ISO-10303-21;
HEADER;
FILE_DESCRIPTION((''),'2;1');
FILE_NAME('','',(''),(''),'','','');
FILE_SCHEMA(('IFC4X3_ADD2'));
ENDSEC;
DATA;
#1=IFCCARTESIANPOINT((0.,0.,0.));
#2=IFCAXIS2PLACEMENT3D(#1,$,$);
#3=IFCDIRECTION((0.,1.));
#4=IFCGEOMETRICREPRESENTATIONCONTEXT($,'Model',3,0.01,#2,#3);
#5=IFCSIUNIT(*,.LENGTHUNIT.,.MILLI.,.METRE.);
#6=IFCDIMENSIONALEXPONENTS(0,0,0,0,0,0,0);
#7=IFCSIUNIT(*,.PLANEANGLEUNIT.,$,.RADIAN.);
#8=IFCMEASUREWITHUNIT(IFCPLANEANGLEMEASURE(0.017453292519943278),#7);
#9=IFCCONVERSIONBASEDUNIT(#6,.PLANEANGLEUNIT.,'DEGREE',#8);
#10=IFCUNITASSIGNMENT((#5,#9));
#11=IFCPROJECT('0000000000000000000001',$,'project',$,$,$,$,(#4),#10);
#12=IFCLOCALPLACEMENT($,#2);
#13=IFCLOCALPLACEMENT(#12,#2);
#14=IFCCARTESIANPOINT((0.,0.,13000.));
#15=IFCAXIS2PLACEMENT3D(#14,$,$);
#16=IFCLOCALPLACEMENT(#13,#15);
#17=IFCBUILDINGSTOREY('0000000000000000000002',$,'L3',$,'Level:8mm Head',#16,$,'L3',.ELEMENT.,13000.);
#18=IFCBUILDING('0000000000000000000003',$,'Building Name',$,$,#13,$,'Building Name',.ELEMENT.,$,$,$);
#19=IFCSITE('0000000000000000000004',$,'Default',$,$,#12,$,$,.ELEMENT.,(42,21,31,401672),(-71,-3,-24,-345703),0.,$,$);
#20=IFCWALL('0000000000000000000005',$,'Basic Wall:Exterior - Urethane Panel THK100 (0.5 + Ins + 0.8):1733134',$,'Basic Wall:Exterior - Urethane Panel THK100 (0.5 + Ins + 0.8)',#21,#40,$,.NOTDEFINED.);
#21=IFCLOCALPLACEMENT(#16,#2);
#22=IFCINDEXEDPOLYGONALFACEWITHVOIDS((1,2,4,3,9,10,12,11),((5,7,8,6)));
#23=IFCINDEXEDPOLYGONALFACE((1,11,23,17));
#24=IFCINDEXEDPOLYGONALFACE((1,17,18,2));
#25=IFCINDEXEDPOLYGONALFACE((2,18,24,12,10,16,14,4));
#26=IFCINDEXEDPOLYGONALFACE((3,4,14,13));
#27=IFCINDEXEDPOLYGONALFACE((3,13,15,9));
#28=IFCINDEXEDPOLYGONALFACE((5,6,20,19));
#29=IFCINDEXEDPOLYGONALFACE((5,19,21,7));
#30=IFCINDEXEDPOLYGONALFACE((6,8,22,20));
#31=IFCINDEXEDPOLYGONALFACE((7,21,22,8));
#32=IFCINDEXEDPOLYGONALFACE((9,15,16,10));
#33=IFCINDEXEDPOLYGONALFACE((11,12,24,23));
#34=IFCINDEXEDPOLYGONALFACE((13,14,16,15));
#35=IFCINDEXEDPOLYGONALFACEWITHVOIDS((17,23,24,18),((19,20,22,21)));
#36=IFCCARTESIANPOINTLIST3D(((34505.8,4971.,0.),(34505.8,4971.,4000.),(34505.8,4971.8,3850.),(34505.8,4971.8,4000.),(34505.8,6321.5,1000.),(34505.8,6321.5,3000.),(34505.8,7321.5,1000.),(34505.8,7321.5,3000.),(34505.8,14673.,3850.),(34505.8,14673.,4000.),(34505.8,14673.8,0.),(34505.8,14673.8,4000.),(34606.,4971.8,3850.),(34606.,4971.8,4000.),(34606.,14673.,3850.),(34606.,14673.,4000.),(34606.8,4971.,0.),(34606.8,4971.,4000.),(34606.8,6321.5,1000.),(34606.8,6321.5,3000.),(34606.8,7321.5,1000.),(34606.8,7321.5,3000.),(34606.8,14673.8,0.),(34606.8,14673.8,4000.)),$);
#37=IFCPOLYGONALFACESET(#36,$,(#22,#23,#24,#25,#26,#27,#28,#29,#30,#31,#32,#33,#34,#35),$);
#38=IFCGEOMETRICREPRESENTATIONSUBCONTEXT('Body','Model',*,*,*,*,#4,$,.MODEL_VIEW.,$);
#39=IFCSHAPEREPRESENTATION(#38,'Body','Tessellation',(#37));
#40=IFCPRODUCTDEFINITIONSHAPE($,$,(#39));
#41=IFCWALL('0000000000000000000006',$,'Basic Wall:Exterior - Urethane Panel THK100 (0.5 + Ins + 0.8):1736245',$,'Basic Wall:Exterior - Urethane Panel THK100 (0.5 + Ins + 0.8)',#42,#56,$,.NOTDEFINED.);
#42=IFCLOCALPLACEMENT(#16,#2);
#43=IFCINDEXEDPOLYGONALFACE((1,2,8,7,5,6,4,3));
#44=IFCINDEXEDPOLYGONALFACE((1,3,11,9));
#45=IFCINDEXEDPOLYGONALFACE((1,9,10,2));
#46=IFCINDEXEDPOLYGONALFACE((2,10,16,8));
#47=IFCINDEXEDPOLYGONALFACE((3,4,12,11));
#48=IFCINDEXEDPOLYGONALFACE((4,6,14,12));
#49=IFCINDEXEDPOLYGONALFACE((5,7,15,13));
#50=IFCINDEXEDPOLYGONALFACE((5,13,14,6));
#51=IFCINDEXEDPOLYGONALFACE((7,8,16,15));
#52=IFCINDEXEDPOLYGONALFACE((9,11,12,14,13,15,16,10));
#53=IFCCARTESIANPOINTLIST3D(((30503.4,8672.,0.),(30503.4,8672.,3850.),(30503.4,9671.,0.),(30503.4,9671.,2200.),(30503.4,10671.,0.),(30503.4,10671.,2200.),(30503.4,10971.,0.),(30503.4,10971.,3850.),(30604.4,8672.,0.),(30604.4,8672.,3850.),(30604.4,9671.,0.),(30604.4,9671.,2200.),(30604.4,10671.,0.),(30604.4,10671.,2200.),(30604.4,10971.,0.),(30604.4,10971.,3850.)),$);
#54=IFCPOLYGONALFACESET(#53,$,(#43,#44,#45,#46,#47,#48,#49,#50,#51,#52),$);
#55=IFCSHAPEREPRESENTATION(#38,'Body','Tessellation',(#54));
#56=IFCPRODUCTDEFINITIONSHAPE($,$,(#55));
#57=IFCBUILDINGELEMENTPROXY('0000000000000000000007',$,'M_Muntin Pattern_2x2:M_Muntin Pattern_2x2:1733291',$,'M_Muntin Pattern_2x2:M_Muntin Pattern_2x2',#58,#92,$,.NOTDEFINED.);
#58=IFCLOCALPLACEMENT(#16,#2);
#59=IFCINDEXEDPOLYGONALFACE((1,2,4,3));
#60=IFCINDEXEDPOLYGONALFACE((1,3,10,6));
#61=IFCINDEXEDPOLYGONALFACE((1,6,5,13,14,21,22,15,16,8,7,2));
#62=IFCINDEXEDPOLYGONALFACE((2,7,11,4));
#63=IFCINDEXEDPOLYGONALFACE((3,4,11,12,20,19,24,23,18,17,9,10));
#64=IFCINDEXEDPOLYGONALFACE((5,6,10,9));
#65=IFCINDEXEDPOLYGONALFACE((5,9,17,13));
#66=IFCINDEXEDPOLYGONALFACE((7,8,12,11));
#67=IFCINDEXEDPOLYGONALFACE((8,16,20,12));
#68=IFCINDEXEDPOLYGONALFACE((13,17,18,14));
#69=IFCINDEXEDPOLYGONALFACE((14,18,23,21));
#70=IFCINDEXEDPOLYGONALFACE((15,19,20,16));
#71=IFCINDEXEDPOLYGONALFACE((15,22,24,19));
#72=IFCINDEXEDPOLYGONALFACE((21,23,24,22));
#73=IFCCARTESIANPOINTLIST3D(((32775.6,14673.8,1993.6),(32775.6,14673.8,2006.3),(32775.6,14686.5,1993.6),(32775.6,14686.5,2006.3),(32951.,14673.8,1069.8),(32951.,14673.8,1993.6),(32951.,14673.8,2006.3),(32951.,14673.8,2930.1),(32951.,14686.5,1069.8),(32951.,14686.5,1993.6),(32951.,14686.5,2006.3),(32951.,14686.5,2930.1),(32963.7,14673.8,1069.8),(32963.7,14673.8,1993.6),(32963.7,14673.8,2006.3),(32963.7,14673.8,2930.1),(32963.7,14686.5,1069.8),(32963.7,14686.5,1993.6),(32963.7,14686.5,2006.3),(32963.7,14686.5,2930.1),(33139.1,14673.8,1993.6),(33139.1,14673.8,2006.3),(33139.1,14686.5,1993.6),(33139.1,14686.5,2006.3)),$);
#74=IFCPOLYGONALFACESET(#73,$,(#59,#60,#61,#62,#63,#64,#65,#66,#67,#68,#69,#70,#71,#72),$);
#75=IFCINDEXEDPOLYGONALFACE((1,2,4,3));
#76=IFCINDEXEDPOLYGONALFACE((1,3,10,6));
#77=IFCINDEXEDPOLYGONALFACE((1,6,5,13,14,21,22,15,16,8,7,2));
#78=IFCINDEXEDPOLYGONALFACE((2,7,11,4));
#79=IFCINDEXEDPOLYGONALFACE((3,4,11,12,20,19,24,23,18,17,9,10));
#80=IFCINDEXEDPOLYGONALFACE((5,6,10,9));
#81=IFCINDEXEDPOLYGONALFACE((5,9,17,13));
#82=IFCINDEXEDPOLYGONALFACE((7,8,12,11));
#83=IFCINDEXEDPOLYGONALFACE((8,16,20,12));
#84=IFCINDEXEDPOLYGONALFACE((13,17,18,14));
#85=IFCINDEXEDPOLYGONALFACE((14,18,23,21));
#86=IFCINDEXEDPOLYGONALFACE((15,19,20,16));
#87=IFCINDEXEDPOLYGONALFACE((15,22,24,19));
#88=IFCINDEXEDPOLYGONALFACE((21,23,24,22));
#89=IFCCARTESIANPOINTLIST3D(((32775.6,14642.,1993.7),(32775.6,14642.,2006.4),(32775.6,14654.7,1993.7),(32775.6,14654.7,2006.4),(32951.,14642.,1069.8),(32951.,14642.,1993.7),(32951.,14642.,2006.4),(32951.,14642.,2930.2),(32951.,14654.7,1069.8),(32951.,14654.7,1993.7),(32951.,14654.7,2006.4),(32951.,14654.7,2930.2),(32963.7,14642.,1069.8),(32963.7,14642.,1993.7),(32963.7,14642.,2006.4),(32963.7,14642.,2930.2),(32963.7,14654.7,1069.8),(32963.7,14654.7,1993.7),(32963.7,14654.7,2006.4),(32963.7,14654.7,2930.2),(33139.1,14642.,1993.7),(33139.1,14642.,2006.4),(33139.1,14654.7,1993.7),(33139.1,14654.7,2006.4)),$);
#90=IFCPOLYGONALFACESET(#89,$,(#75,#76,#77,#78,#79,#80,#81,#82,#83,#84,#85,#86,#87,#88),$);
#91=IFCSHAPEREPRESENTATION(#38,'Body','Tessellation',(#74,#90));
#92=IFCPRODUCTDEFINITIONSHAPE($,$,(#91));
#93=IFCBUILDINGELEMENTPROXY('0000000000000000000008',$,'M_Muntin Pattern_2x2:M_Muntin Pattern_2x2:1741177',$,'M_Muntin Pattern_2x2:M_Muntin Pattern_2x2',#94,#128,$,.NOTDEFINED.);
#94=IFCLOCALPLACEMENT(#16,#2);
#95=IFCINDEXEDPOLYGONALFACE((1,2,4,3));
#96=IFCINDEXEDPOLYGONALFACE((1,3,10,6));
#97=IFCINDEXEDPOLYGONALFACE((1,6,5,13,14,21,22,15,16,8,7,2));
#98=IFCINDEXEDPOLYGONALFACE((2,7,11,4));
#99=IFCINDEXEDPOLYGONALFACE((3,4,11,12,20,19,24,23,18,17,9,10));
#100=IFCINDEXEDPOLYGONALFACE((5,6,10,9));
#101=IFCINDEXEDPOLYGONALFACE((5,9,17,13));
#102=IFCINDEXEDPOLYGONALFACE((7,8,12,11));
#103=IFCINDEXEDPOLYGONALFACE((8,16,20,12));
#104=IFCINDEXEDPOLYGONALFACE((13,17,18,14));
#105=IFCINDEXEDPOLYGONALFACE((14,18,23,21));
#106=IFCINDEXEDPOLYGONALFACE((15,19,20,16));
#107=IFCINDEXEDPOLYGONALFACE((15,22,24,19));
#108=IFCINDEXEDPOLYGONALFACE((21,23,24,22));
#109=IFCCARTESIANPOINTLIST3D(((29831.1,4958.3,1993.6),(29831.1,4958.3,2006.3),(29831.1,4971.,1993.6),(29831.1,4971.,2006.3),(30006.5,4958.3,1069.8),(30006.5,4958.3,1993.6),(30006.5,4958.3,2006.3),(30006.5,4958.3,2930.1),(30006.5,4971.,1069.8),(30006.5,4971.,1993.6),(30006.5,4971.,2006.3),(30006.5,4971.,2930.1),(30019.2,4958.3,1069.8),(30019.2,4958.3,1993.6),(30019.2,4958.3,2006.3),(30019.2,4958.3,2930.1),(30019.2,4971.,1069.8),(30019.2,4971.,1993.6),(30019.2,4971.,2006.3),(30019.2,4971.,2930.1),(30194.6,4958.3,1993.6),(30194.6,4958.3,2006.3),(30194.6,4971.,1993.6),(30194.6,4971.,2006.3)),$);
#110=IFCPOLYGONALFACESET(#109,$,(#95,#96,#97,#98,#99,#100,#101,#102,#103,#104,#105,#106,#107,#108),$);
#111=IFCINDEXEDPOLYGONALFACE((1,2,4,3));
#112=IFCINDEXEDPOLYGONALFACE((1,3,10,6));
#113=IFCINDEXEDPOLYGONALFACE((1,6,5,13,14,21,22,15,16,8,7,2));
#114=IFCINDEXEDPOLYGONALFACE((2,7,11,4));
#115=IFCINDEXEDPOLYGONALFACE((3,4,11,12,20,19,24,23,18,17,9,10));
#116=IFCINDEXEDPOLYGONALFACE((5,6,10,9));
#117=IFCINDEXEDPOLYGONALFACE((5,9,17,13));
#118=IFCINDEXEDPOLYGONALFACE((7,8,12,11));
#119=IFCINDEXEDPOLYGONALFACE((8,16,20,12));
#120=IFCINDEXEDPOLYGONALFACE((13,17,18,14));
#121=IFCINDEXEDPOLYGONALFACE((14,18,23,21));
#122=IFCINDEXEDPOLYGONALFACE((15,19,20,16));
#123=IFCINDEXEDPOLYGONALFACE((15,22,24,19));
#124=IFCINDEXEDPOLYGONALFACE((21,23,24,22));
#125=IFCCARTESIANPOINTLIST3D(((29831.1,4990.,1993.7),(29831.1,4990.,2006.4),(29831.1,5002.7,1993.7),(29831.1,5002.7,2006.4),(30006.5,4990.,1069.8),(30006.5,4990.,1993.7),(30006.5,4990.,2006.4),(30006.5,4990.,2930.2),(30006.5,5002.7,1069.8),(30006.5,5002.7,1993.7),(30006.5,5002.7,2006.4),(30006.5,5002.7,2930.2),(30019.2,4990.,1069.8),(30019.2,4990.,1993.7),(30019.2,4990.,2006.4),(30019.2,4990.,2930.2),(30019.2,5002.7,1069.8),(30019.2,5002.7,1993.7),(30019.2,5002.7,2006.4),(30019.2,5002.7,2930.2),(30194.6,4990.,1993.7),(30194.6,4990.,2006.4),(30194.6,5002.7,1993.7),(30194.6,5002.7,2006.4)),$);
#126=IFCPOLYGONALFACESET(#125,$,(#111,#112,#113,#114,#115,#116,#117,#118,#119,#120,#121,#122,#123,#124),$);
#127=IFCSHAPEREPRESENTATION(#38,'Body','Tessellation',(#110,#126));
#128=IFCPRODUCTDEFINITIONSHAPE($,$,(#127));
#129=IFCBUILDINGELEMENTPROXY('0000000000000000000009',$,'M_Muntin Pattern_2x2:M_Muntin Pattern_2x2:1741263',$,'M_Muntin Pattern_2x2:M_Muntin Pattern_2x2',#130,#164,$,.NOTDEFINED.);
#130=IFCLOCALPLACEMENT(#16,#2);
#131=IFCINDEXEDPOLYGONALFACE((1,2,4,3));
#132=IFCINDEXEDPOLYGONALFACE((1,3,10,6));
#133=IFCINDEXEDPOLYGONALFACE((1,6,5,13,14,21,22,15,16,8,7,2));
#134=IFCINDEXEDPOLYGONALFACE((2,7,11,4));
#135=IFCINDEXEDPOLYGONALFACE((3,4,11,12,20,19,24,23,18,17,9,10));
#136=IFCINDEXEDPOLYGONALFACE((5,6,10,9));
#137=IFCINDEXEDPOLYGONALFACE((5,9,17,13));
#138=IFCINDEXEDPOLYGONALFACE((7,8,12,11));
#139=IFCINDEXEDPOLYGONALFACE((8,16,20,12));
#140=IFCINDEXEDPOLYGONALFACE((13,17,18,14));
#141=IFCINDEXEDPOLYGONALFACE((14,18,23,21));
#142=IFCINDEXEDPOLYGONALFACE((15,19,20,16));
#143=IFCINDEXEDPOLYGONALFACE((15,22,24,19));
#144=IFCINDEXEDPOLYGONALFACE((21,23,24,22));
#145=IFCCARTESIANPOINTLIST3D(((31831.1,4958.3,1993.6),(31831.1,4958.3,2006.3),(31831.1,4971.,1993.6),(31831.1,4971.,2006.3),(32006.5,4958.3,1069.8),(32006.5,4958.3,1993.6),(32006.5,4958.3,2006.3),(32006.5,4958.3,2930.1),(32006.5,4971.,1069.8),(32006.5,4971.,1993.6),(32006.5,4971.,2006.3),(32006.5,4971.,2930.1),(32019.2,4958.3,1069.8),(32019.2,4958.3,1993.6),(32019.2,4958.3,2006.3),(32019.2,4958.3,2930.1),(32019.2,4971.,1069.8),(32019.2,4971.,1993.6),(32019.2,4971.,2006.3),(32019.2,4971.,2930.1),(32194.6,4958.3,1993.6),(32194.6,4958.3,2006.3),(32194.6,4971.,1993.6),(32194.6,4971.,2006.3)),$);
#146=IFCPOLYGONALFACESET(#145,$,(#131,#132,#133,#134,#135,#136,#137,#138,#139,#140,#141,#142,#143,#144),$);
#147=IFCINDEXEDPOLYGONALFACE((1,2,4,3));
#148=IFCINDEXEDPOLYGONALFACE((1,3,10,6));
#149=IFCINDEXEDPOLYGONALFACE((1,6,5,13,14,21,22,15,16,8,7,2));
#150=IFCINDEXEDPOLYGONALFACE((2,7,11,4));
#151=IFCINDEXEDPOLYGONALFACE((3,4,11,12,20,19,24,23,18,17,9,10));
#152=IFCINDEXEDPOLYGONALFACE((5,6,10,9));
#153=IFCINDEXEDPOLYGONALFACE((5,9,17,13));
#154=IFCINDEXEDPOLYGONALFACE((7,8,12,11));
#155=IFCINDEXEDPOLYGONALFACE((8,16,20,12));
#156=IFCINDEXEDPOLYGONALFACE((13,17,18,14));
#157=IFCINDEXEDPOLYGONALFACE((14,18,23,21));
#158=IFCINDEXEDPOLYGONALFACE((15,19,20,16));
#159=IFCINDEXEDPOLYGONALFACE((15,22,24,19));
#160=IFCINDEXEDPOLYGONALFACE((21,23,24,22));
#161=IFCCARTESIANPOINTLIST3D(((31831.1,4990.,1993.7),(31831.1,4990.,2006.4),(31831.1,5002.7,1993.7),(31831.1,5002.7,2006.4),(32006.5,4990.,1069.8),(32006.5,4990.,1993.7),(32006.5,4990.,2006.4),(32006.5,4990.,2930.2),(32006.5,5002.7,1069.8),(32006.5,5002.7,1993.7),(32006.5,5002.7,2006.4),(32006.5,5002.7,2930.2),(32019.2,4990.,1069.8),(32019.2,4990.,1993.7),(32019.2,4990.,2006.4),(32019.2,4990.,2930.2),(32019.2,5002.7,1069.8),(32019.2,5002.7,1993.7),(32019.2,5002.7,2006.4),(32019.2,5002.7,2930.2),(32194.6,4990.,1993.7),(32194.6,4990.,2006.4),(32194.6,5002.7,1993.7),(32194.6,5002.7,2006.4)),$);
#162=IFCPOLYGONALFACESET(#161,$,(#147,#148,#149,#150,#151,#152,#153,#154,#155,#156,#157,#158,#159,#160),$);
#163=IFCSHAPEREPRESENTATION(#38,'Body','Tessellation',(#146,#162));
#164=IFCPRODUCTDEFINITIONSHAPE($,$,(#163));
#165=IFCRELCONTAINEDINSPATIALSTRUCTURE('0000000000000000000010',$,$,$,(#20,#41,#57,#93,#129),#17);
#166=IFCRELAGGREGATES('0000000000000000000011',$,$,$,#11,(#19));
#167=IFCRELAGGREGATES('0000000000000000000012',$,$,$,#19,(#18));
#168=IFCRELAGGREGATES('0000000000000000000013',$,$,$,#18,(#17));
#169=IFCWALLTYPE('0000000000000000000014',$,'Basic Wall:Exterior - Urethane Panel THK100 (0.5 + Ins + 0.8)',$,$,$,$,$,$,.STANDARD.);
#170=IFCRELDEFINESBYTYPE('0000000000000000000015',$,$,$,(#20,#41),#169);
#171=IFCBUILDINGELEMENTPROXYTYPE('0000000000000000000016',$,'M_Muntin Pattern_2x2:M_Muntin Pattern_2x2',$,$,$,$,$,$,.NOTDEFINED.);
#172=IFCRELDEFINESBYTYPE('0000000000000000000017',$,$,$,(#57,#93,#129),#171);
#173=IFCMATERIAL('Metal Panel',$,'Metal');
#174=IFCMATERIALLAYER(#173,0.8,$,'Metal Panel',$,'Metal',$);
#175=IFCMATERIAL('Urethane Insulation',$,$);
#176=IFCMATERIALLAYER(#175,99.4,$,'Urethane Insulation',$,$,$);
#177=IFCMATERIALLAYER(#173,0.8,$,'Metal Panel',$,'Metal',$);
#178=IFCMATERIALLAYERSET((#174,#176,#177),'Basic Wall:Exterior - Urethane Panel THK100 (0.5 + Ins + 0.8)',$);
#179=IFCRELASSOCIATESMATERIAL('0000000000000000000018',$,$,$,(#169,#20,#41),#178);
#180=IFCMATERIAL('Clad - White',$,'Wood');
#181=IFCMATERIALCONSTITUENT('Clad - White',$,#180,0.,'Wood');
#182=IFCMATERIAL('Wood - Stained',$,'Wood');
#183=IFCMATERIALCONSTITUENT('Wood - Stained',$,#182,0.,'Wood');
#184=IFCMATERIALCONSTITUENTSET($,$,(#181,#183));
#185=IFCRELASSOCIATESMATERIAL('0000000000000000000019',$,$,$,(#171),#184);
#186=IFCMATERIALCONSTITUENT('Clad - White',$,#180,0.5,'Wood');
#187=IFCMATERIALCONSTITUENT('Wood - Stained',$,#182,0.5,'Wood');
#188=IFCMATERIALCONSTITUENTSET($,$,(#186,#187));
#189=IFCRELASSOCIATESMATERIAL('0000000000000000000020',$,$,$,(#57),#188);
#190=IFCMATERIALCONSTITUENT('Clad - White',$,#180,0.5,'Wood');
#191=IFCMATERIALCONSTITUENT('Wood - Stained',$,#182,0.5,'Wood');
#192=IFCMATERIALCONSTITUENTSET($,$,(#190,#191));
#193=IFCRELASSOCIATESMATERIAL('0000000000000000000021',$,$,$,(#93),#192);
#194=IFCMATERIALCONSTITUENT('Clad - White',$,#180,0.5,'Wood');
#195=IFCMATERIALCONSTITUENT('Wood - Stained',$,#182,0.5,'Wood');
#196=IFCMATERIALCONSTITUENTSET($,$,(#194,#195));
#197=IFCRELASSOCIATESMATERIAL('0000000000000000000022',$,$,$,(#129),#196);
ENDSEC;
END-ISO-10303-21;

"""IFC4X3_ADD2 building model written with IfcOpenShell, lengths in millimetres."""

from ifc_helpers import new_model, entity, si_unit, converted_unit, direction, frame, frame_2d, origin, place, context, subcontext, project, spatial, polyline, rectangle, outline, extrude, clip, bounded_halfspace, source, transform, mapped, material, layer, layer_set, constituent, constituent_set, type_object, type_shapes, element, save


model = new_model("IFC4X3_ADD2")

# Units and contexts
model_context = context("Model", 3, precision=0.01, world=origin(), true_north=direction((0.0, 1.0)))
body_context = subcontext(model_context, "Body", "Model", "MODEL_VIEW")
ifc_project = project(units=[si_unit("LENGTHUNIT", "METRE", prefix="MILLI"), converted_unit("PLANEANGLEUNIT", "DEGREE", entity("IfcPlaneAngleMeasure", 0.017453292519943278), si_unit("PLANEANGLEUNIT", "RADIAN"), dimensions=[0, 0, 0, 0, 0, 0, 0])], contexts=[model_context])

# Site, building, storey
site_placement = place(None, origin())
site = spatial("IfcSite", under=ifc_project, at=site_placement, Name="Default", CompositionType="ELEMENT", RefLatitude=(42, 21, 31, 401672), RefLongitude=(-71, -3, -24, -345703), RefElevation=0.0)
building_placement = place(site_placement, origin())
building = spatial("IfcBuilding", under=site, at=building_placement, Name="Building Name", LongName="Building Name", CompositionType="ELEMENT")
storey_placement = place(building_placement, frame((0.0, 0.0, 13000.0)))
storey = spatial("IfcBuildingStorey", under=building, at=storey_placement, Name="L3", ObjectType="Level:8mm Head", LongName="L3", CompositionType="ELEMENT", Elevation=13000.0)

# Walls, openings
ifc_material_1 = material(Name="Metal Panel", Category="Metal")
ifc_layer_1 = layer(ifc_material_1, 0.8, Name="Metal Panel", Category="Metal")
ifc_material_2 = material(Name="Urethane Insulation")
ifc_layer_2 = layer(ifc_material_2, 99.4, Name="Urethane Insulation")
ifc_layer_3 = layer(ifc_material_1, 0.8, Name="Metal Panel", Category="Metal")
ifc_layer_set = layer_set([ifc_layer_1, ifc_layer_2, ifc_layer_3], Name="Basic Wall:Exterior - Urethane Panel THK100 (0.5 + Ins + 0.8)")
wall_type = type_object("IfcWallType", Name="Basic Wall:Exterior - Urethane Panel THK100 (0.5 + Ins + 0.8)", PredefinedType="STANDARD", material=ifc_layer_set)
wall_1_placement = place(storey_placement, frame((34556.3, 14673.8, 0.0), z_axis=(0.0, 0.0, 1.0), x_axis=(0.0, -1.0, 0.0)))
wall_1 = element("IfcWall", 1, at=wall_1_placement, inside=storey, type_object=wall_type, material=ifc_layer_set, Name="Basic Wall:Exterior - Urethane Panel THK100 (0.5 + Ins + 0.8):1733134", ObjectType="Basic Wall:Exterior - Urethane Panel THK100 (0.5 + Ins + 0.8)", PredefinedType="NOTDEFINED", context=body_context, shape_type="Clipping", body=[
    clip(extrude(rectangle(XDim=9702.8, YDim=101.0, at=frame_2d((4851.4, 0.0), x_axis=(-1.0, 0.0))), origin(), (0.0, 0.0, 1.0), 4000.0), bounded_halfspace(frame((0.8, -50.5, 3850.0), z_axis=(0.0, 0.0, -1.0), x_axis=(-1.0, 0.0, 0.0)), True, frame((0.8, -50.5, 3850.0)), polyline([(0.0, 0.0), (100.2, 0.0), (3601.0, 0.0), (3702.0, 0.0), (6001.0, 0.0), (6102.0, 0.0), (9601.0, 0.0), (9701.2, 0.0), (9701.2, 100.2), (0.0, 100.2), (0.0, 0.0)]))),
])
opening_1_placement = place(wall_1_placement, frame((7352.3, -50.5, 1000.0)))
element("IfcOpeningElement", 2, at=opening_1_placement, cuts=wall_1, PredefinedType="OPENING", context=body_context, shape_type="SweptSolid", body=[
    extrude(rectangle(XDim=2000.0, YDim=1000.0, at=frame_2d((1000.0, 500.0), x_axis=(-1.0, 0.0))), frame((0.0, 0.0, 0.0), z_axis=(0.0, 1.0, 0.0), x_axis=(0.0, 0.0, 1.0)), (0.0, 0.0, 1.0), 101.0),
])
wall_2_placement = place(storey_placement, frame((30553.9, 10971.0, 0.0), z_axis=(0.0, 0.0, 1.0), x_axis=(0.0, -1.0, 0.0)))
wall_2 = element("IfcWall", 3, at=wall_2_placement, inside=storey, type_object=wall_type, material=ifc_layer_set, Name="Basic Wall:Exterior - Urethane Panel THK100 (0.5 + Ins + 0.8):1736245", ObjectType="Basic Wall:Exterior - Urethane Panel THK100 (0.5 + Ins + 0.8)", PredefinedType="NOTDEFINED", context=body_context, shape_type="Clipping", body=[
    clip(extrude(rectangle(XDim=2299.0, YDim=101.0, at=frame_2d((1149.5, 0.0), x_axis=(-1.0, 0.0))), origin(), (0.0, 0.0, 1.0), 3850.0), bounded_halfspace(frame((0.0, -50.5, 3850.0), z_axis=(0.0, 0.0, -1.0), x_axis=(-1.0, 0.0, 0.0)), True, frame((0.0, -50.5, 3850.0)), polyline([(0.0, 0.0), (2299.0, 0.0), (2299.0, 101.0), (0.0, 101.0), (0.0, 0.0)]))),
])
opening_2_placement = place(wall_2_placement, frame((300.0, -50.5, 0.0)))
element("IfcOpeningElement", 4, at=opening_2_placement, cuts=wall_2, PredefinedType="OPENING", context=body_context, shape_type="SweptSolid", body=[
    extrude(rectangle(XDim=2200.0, YDim=1000.0, at=frame_2d((1100.0, 500.0), x_axis=(1.0, 0.0))), frame((0.0, 0.0, 0.0), z_axis=(0.0, 1.0, 0.0), x_axis=(0.0, 0.0, 1.0)), (0.0, 0.0, 1.0), 101.0),
])

# Building element proxies
ifc_material_3 = material(Name="Clad - White", Category="Wood")
ifc_constituent_1 = constituent(ifc_material_3, Name="Clad - White", Category="Wood", fraction=0.5)
ifc_material_4 = material(Name="Wood - Stained", Category="Wood")
ifc_constituent_2 = constituent(ifc_material_4, Name="Wood - Stained", Category="Wood", fraction=0.5)
ifc_constituent_set_1 = constituent_set(constituents=[ifc_constituent_1, ifc_constituent_2])
ifc_constituent_3 = constituent(ifc_material_3, Name="Clad - White", Category="Wood", fraction=0.0)
ifc_constituent_4 = constituent(ifc_material_4, Name="Wood - Stained", Category="Wood", fraction=0.0)
ifc_constituent_set_2 = constituent_set(constituents=[ifc_constituent_3, ifc_constituent_4])
building_element_proxy_type_1 = type_object("IfcBuildingElementProxyType", Name="M_Muntin Pattern_2x2:M_Muntin Pattern_2x2", PredefinedType="NOTDEFINED", material=ifc_constituent_set_2)
shared_shape_1 = source(origin(), body_context, "Body", "SweptSolid", [
    extrude(outline(polyline([(6.4, -6.4), (930.1, -6.4), (930.1, 6.3), (6.4, 6.3), (6.4, 181.7), (-6.3, 181.7), (-6.3, 6.3), (-930.2, 6.3), (-930.2, -6.4), (-6.3, -6.4), (-6.3, -181.7), (6.4, -181.7), (6.4, -6.4)])), frame((0.0, 9.5, 930.1), z_axis=(0.0, 1.0, 0.0), x_axis=(0.0, 0.0, 1.0)), (0.0, 0.0, 1.0), 12.7),
    extrude(outline(polyline([(6.4, -6.4), (930.2, -6.4), (930.2, 6.3), (6.4, 6.3), (6.4, 181.7), (-6.3, 181.7), (-6.3, 6.3), (-930.2, 6.3), (-930.2, -6.4), (-6.3, -6.4), (-6.3, -181.7), (6.4, -181.7), (6.4, -6.4)])), frame((0.0, -22.2, 930.2), z_axis=(0.0, 1.0, 0.0), x_axis=(0.0, 0.0, 1.0)), (0.0, 0.0, 1.0), 12.7),
])
type_shapes(building_element_proxy_type_1, [shared_shape_1])
proxy_1_placement = place(storey_placement, frame((32957.4, 14664.3, 1069.8)))
element("IfcBuildingElementProxy", 5, at=proxy_1_placement, inside=storey, type_object=building_element_proxy_type_1, material=ifc_constituent_set_1, Name="M_Muntin Pattern_2x2:M_Muntin Pattern_2x2:1733291", ObjectType="M_Muntin Pattern_2x2:M_Muntin Pattern_2x2", PredefinedType="NOTDEFINED", context=body_context, shape_type="MappedRepresentation", body=[
    mapped(shared_shape_1, transform((0.0, 0.0, 0.0), scale=1.0)),
])
ifc_constituent_5 = constituent(ifc_material_3, Name="Clad - White", Category="Wood", fraction=0.5)
ifc_constituent_6 = constituent(ifc_material_4, Name="Wood - Stained", Category="Wood", fraction=0.5)
ifc_constituent_set_3 = constituent_set(constituents=[ifc_constituent_5, ifc_constituent_6])
proxy_2_placement = place(storey_placement, frame((30012.8, 4980.5, 1069.8), z_axis=(0.0, 0.0, 1.0), x_axis=(-1.0, 0.0, 0.0)))
element("IfcBuildingElementProxy", 6, at=proxy_2_placement, inside=storey, type_object=building_element_proxy_type_1, material=ifc_constituent_set_3, Name="M_Muntin Pattern_2x2:M_Muntin Pattern_2x2:1741177", ObjectType="M_Muntin Pattern_2x2:M_Muntin Pattern_2x2", PredefinedType="NOTDEFINED", context=body_context, shape_type="MappedRepresentation", body=[
    mapped(shared_shape_1, transform((0.0, 0.0, 0.0), scale=1.0)),
])
ifc_constituent_7 = constituent(ifc_material_3, Name="Clad - White", Category="Wood", fraction=0.5)
ifc_constituent_8 = constituent(ifc_material_4, Name="Wood - Stained", Category="Wood", fraction=0.5)
ifc_constituent_set_4 = constituent_set(constituents=[ifc_constituent_7, ifc_constituent_8])
proxy_3_placement = place(storey_placement, frame((32012.8, 4980.5, 1069.8), z_axis=(0.0, 0.0, 1.0), x_axis=(-1.0, 0.0, 0.0)))
element("IfcBuildingElementProxy", 7, at=proxy_3_placement, inside=storey, type_object=building_element_proxy_type_1, material=ifc_constituent_set_4, Name="M_Muntin Pattern_2x2:M_Muntin Pattern_2x2:1741263", ObjectType="M_Muntin Pattern_2x2:M_Muntin Pattern_2x2", PredefinedType="NOTDEFINED", context=body_context, shape_type="MappedRepresentation", body=[
    mapped(shared_shape_1, transform((0.0, 0.0, 0.0), scale=1.0)),
])

save(model, "model.ifc")
